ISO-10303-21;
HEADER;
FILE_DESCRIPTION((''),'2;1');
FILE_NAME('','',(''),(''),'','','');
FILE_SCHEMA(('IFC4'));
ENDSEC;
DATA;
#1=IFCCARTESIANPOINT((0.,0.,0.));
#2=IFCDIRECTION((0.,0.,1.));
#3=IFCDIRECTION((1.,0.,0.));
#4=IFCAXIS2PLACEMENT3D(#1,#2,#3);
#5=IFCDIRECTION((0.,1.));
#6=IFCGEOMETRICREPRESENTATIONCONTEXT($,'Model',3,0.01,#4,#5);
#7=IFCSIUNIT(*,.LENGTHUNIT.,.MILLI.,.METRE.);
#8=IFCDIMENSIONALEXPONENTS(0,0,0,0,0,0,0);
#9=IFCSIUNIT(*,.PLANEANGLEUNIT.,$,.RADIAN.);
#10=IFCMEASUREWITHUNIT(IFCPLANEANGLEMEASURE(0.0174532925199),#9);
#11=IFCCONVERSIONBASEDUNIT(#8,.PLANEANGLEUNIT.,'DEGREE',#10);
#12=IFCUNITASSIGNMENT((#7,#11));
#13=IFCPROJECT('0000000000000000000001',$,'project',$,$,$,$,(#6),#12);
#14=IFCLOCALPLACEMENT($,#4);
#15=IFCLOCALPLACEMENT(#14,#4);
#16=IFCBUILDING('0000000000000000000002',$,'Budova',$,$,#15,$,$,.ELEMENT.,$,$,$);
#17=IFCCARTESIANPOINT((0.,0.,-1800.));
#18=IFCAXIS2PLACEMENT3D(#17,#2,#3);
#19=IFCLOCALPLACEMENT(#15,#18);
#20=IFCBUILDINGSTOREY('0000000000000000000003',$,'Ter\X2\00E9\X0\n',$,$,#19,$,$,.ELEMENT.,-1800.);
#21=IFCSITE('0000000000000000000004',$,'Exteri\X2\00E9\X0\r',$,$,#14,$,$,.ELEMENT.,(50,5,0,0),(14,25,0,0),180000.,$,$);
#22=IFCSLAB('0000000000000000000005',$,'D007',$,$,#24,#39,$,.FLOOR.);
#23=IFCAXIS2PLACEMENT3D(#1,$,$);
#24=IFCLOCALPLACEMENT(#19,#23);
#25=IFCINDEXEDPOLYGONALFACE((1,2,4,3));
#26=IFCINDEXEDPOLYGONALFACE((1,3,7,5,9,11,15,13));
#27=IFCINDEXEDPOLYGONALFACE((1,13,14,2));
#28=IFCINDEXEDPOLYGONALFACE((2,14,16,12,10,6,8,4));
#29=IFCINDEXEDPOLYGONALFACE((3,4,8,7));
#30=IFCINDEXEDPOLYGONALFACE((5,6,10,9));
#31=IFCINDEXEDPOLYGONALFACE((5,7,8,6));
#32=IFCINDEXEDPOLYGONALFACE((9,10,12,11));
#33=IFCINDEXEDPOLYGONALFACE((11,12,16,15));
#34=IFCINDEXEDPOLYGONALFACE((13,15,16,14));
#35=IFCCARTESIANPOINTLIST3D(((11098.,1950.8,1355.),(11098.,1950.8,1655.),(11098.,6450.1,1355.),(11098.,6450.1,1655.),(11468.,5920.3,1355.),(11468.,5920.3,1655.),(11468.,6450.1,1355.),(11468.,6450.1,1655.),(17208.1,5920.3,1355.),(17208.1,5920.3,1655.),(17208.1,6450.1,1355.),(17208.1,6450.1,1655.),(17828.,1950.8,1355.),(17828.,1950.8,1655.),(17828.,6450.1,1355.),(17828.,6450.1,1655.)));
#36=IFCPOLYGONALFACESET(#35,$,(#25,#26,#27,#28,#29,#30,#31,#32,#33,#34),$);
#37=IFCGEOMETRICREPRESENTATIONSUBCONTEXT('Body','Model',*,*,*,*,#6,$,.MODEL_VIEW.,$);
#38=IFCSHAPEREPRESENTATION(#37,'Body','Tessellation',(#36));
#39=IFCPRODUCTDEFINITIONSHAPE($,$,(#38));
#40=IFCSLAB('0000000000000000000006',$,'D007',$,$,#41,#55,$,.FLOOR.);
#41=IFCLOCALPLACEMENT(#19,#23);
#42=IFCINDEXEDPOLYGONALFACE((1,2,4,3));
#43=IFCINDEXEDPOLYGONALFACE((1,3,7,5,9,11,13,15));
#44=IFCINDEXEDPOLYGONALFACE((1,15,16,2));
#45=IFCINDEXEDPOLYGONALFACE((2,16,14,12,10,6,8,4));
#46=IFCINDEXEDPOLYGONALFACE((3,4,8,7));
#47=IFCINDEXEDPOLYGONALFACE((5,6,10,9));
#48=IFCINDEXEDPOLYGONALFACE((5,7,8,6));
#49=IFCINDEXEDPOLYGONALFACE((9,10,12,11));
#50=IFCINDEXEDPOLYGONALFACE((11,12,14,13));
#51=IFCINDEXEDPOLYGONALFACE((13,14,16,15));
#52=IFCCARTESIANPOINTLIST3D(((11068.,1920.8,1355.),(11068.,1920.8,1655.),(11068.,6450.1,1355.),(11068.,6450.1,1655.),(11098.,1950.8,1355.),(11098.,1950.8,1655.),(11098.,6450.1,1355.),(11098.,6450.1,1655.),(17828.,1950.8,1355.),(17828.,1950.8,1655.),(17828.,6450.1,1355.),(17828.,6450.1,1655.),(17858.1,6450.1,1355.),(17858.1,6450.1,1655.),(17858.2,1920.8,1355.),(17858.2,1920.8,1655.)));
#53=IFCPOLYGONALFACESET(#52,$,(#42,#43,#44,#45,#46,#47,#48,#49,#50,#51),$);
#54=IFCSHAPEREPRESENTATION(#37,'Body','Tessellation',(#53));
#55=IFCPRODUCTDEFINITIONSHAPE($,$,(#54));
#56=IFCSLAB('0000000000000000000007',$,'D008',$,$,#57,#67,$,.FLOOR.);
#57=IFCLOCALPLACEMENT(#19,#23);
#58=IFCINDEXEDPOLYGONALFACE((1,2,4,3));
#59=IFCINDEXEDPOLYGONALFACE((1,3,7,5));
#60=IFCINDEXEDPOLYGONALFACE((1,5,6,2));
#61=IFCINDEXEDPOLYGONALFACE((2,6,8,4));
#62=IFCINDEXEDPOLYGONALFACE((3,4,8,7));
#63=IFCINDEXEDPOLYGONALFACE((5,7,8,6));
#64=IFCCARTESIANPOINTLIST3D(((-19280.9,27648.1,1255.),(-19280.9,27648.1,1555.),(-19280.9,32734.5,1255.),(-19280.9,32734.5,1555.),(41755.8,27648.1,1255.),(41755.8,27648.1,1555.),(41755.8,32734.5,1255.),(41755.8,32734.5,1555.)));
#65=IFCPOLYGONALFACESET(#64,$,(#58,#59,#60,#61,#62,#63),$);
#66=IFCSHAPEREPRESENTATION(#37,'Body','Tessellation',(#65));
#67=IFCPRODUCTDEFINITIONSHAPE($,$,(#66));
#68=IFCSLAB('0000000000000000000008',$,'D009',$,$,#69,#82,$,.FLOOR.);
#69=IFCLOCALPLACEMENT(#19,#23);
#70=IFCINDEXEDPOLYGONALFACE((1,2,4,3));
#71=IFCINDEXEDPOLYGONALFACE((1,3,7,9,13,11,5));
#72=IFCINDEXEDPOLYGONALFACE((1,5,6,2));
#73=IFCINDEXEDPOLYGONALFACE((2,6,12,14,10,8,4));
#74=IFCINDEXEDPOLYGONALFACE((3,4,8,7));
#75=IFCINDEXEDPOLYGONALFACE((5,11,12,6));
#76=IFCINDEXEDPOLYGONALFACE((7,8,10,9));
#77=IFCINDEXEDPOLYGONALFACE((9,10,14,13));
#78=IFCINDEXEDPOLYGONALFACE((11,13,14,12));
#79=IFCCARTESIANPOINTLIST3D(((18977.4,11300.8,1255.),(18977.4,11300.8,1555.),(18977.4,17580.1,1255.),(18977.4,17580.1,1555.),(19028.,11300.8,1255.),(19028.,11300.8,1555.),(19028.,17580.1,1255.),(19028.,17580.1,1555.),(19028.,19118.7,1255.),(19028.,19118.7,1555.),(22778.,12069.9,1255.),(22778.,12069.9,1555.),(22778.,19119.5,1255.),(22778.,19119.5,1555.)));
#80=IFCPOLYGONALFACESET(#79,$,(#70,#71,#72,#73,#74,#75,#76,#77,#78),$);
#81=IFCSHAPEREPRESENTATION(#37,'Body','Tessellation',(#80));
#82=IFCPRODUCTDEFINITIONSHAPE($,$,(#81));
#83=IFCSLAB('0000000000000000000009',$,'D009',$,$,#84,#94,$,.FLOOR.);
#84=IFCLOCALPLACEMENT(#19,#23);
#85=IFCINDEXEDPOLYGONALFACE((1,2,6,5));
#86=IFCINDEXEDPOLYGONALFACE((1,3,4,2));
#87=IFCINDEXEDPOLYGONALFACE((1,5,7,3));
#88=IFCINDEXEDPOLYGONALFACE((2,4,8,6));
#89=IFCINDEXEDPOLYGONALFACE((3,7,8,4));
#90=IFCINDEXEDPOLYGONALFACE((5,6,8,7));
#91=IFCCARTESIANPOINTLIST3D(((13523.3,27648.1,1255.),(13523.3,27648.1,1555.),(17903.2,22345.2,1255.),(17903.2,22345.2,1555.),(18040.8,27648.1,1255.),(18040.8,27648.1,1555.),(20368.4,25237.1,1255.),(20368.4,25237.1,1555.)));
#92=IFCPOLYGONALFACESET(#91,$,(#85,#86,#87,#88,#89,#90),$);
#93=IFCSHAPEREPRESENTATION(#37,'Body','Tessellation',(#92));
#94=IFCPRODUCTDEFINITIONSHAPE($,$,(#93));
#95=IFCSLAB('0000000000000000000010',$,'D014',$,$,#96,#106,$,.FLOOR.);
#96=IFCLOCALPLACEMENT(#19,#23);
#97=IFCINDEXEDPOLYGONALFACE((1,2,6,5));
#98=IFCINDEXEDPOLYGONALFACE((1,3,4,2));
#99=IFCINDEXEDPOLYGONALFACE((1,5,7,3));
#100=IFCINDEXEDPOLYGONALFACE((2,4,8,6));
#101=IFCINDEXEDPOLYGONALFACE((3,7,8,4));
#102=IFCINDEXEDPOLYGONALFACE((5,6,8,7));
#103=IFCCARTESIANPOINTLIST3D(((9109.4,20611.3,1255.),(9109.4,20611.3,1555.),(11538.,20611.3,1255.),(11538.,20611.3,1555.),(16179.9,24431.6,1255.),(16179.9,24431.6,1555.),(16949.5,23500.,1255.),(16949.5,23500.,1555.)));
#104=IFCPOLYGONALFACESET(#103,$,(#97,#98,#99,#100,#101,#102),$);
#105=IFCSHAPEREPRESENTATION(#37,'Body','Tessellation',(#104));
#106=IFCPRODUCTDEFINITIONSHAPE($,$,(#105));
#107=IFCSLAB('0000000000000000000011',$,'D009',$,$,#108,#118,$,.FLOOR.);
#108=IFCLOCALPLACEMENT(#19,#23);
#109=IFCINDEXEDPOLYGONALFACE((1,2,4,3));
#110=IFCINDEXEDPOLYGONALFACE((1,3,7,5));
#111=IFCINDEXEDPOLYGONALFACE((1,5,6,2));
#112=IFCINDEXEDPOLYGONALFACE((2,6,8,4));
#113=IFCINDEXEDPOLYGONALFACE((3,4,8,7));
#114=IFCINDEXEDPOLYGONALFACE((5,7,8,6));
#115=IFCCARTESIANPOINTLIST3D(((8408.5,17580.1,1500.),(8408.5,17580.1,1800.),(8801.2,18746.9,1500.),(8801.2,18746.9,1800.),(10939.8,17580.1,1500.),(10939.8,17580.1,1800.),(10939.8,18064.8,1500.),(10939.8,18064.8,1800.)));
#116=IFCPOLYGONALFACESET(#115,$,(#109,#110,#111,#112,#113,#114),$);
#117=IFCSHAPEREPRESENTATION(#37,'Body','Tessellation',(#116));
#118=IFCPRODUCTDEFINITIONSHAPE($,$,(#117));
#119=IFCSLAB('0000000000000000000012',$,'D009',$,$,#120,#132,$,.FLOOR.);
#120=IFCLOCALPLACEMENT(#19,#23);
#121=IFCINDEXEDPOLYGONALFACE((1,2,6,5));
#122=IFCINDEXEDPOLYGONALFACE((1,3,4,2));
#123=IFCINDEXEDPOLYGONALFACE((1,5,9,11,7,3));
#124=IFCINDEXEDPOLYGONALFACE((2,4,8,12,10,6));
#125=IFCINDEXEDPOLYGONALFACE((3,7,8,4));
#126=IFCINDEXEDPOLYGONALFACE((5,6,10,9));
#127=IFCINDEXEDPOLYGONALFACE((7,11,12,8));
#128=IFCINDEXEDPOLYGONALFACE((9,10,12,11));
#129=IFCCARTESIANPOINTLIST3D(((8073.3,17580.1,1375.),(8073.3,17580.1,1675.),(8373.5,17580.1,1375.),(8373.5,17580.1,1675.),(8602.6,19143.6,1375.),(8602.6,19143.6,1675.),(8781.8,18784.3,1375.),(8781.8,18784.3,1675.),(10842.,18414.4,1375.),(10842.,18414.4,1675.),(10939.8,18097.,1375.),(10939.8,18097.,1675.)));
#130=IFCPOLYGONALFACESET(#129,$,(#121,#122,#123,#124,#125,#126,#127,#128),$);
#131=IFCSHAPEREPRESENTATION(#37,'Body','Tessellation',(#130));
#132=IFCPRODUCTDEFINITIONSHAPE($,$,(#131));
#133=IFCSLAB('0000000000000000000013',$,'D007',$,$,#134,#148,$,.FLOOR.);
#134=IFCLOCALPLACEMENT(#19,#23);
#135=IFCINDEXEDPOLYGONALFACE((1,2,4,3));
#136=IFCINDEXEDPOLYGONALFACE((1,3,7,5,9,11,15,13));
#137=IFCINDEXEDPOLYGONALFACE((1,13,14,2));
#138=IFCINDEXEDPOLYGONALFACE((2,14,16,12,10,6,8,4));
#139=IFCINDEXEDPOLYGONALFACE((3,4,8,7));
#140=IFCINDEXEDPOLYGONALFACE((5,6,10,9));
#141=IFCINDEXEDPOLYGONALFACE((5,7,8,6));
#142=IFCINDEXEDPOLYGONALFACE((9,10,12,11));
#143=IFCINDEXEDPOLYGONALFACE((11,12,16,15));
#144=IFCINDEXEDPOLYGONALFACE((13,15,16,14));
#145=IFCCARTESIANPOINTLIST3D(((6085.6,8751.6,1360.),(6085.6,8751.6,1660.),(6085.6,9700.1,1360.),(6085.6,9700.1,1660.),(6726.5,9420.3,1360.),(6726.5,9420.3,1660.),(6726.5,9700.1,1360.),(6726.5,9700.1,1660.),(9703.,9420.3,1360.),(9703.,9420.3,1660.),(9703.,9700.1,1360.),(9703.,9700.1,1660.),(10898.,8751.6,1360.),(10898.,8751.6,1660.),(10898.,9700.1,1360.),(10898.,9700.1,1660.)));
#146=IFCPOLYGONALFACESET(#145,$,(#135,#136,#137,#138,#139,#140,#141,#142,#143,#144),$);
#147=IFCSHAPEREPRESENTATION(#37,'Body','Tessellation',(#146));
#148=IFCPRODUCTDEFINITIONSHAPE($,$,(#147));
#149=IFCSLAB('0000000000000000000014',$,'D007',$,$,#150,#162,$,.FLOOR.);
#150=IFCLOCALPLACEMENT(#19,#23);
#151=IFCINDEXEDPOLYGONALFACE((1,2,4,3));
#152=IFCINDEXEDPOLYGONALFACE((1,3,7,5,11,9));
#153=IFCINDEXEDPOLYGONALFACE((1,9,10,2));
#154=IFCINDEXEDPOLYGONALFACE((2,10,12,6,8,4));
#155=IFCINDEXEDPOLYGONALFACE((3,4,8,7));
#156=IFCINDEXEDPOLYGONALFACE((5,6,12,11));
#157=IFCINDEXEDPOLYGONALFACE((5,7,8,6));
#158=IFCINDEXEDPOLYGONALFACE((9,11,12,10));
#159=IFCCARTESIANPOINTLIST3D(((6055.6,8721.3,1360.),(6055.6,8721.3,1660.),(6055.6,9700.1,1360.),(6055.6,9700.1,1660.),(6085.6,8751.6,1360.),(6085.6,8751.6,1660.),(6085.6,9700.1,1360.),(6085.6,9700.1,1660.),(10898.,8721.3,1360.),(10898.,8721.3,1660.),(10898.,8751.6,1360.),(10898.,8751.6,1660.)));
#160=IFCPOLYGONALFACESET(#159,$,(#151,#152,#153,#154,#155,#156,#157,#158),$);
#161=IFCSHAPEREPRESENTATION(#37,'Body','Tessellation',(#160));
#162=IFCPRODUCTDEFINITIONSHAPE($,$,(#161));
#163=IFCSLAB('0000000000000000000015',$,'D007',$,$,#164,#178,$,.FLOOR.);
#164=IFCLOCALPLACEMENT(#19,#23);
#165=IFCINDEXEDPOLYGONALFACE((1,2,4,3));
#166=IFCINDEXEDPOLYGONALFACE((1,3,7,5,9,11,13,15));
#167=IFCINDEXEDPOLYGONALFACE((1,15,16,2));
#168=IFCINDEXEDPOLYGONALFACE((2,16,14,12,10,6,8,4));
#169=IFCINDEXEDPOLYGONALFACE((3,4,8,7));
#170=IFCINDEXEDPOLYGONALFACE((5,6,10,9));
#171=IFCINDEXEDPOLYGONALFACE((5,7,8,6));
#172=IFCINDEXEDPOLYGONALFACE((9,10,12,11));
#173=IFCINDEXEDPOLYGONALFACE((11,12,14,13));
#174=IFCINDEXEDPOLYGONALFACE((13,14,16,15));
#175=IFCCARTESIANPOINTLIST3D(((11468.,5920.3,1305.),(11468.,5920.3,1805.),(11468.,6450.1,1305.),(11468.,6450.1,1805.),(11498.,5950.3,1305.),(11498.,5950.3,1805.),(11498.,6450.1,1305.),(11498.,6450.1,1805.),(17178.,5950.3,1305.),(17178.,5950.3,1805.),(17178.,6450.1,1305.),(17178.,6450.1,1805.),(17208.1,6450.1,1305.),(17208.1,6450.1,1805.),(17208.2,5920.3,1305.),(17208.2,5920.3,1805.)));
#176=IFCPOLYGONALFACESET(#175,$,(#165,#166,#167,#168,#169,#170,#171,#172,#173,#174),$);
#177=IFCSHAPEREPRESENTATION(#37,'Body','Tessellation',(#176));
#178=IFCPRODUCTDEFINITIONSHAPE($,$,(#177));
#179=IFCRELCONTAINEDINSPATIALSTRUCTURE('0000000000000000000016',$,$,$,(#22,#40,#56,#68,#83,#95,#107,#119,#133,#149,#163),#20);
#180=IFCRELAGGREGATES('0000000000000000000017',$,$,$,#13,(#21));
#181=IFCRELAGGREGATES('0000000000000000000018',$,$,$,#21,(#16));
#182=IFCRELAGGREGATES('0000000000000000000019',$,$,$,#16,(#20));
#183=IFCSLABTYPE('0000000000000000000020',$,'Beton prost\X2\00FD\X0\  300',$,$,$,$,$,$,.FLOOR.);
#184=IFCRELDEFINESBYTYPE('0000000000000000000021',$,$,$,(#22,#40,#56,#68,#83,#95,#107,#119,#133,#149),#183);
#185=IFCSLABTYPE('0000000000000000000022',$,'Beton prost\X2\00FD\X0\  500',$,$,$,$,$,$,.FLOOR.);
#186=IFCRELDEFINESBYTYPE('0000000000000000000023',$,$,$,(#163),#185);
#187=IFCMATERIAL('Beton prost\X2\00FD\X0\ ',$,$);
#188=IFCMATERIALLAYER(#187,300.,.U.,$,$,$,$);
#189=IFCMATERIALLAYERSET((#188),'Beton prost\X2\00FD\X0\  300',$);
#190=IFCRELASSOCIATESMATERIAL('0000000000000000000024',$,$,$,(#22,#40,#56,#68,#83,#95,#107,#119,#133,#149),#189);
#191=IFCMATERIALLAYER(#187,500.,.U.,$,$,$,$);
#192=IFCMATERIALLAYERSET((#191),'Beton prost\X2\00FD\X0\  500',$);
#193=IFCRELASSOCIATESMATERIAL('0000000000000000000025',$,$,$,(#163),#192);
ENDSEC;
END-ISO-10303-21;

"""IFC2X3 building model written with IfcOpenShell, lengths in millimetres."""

from ifc_helpers import new_model, entity, si_unit, converted_unit, direction, frame, origin_with_axes, place, context, subcontext, project, spatial, polyline, outline, extrude, material, layer, layer_set, layer_usage, type_object, element, save


model = new_model("IFC2X3")

# Units and contexts
model_context = context("Model", 3, precision=0.01, world=origin_with_axes(), true_north=direction((0.0, 1.0)))
body_context = subcontext(model_context, "Body", "Model", "MODEL_VIEW")
ifc_project = project(units=[si_unit("LENGTHUNIT", "METRE", prefix="MILLI"), converted_unit("PLANEANGLEUNIT", "DEGREE", entity("IfcPlaneAngleMeasure", 0.0174532925199), si_unit("PLANEANGLEUNIT", "RADIAN"), dimensions=[0, 0, 0, 0, 0, 0, 0])], contexts=[model_context])

# Site, building, storey
site_placement = place(None, origin_with_axes())
site = spatial("IfcSite", under=ifc_project, at=site_placement, Name="Exteriér", CompositionType="ELEMENT", RefLatitude=(50, 5, 0, 0), RefLongitude=(14, 25, 0, 0), RefElevation=180000.0)
building_placement = place(site_placement, origin_with_axes())
building = spatial("IfcBuilding", under=site, at=building_placement, Name="Budova", CompositionType="ELEMENT")
storey_placement = place(building_placement, frame((0.0, 0.0, -1800.0), z_axis=(0.0, 0.0, 1.0), x_axis=(1.0, 0.0, 0.0)))
storey = spatial("IfcBuildingStorey", under=building, at=storey_placement, Name="Terén", CompositionType="ELEMENT", Elevation=-1800.0)

# Slabs
ifc_material_1 = material(Name="Beton prostý ")
ifc_layer_1 = layer(ifc_material_1, 300.0, ventilated="UNKNOWN")
ifc_layer_set_1 = layer_set([ifc_layer_1], Name="Beton prostý  300")
ifc_layer_usage_1 = layer_usage(ifc_layer_set_1, "AXIS3", "NEGATIVE", 300.0)
slab_type_1 = type_object("IfcSlabType", Name="Beton prostý  300", PredefinedType="FLOOR")
slab_1_placement = place(storey_placement, frame((11098.0, 1950.8, 1655.0), z_axis=(0.0, 0.0, 1.0), x_axis=(1.0, 0.0, 0.0)))
element("IfcSlab", 1, at=slab_1_placement, inside=storey, type_object=slab_type_1, material=ifc_layer_usage_1, Name="D007", PredefinedType="FLOOR", context=body_context, shape_type="SweptSolid", body=[
    extrude(outline(polyline([(0.0, 0.0), (6730.0, 0.0), (6730.0, 4499.3), (6110.1, 4499.3), (6110.1, 3969.5), (370.0, 3969.5), (370.0, 4499.3), (0.0, 4499.3), (0.0, 0.0)])), frame((0.0, 0.0, -300.0), z_axis=(0.0, 0.0, 1.0), x_axis=(1.0, 0.0, 0.0)), (0.0, 0.0, 1.0), 300.0),
])
ifc_layer_usage_2 = layer_usage(ifc_layer_set_1, "AXIS3", "NEGATIVE", 300.0)
slab_2_placement = place(storey_placement, frame((11068.0, 6450.1, 1655.0), z_axis=(0.0, 0.0, 1.0), x_axis=(1.0, 0.0, 0.0)))
element("IfcSlab", 2, at=slab_2_placement, inside=storey, type_object=slab_type_1, material=ifc_layer_usage_2, Name="D007", PredefinedType="FLOOR", context=body_context, shape_type="SweptSolid", body=[
    extrude(outline(polyline([(0.0, 0.0), (0.0, -4529.3), (6790.2, -4529.3), (6790.1, 0.0), (6760.0, 0.0), (6760.0, -4499.3), (30.0, -4499.3), (30.0, 0.0), (0.0, 0.0)])), frame((0.0, 0.0, -300.0), z_axis=(0.0, 0.0, 1.0), x_axis=(1.0, 0.0, 0.0)), (0.0, 0.0, 1.0), 300.0),
])
ifc_layer_usage_3 = layer_usage(ifc_layer_set_1, "AXIS3", "NEGATIVE", 300.0)
slab_3_placement = place(storey_placement, frame((-19280.9, 27648.1, 1555.0), z_axis=(0.0, 0.0, 1.0), x_axis=(1.0, 0.0, 0.0)))
element("IfcSlab", 3, at=slab_3_placement, inside=storey, type_object=slab_type_1, material=ifc_layer_usage_3, Name="D008", PredefinedType="FLOOR", context=body_context, shape_type="SweptSolid", body=[
    extrude(outline(polyline([(0.0, 0.0), (61036.7, 0.0), (61036.7, 5086.4), (0.0, 5086.4), (0.0, 0.0)])), frame((0.0, 0.0, -300.0), z_axis=(0.0, 0.0, 1.0), x_axis=(1.0, 0.0, 0.0)), (0.0, 0.0, 1.0), 300.0),
])
ifc_layer_usage_4 = layer_usage(ifc_layer_set_1, "AXIS3", "NEGATIVE", 300.0)
slab_4_placement = place(storey_placement, frame((18977.4, 11300.8, 1555.0), z_axis=(0.0, 0.0, 1.0), x_axis=(1.0, 0.0, 0.0)))
element("IfcSlab", 4, at=slab_4_placement, inside=storey, type_object=slab_type_1, material=ifc_layer_usage_4, Name="D009", PredefinedType="FLOOR", context=body_context, shape_type="SweptSolid", body=[
    extrude(outline(polyline([(0.0, 0.0), (50.6, 0.0), (3800.6, 769.0), (3800.6, 7818.7), (50.6, 7817.9), (50.6, 6279.3), (0.0, 6279.3), (0.0, 0.0)])), frame((0.0, 0.0, -300.0), z_axis=(0.0, 0.0, 1.0), x_axis=(1.0, 0.0, 0.0)), (0.0, 0.0, 1.0), 300.0),
])
ifc_layer_usage_5 = layer_usage(ifc_layer_set_1, "AXIS3", "NEGATIVE", 300.0)
slab_5_placement = place(storey_placement, frame((18040.8, 27648.1, 1555.0), z_axis=(0.0, 0.0, 1.0), x_axis=(1.0, 0.0, 0.0)))
element("IfcSlab", 5, at=slab_5_placement, inside=storey, type_object=slab_type_1, material=ifc_layer_usage_5, Name="D009", PredefinedType="FLOOR", context=body_context, shape_type="SweptSolid", body=[
    extrude(outline(polyline([(0.0, 0.0), (-4517.5, 0.0), (-137.5, -5302.9), (2327.6, -2410.9), (0.0, 0.0)])), frame((0.0, 0.0, -300.0), z_axis=(0.0, 0.0, 1.0), x_axis=(1.0, 0.0, 0.0)), (0.0, 0.0, 1.0), 300.0),
])
ifc_layer_usage_6 = layer_usage(ifc_layer_set_1, "AXIS3", "NEGATIVE", 300.0)
slab_6_placement = place(storey_placement, frame((11538.0, 20611.3, 1555.0), z_axis=(0.0, 0.0, 1.0), x_axis=(1.0, 0.0, 0.0)))
element("IfcSlab", 6, at=slab_6_placement, inside=storey, type_object=slab_type_1, material=ifc_layer_usage_6, Name="D014", PredefinedType="FLOOR", context=body_context, shape_type="SweptSolid", body=[
    extrude(outline(polyline([(0.0, 0.0), (5411.4, 2888.6), (4641.9, 3820.3), (-2428.6, 0.0), (0.0, 0.0)])), frame((0.0, 0.0, -300.0), z_axis=(0.0, 0.0, 1.0), x_axis=(1.0, 0.0, 0.0)), (0.0, 0.0, 1.0), 300.0),
])
ifc_layer_usage_7 = layer_usage(ifc_layer_set_1, "AXIS3", "NEGATIVE", 300.0)
slab_7_placement = place(storey_placement, frame((10939.8, 18064.8, 1800.0), z_axis=(0.0, 0.0, 1.0), x_axis=(1.0, 0.0, 0.0)))
element("IfcSlab", 7, at=slab_7_placement, inside=storey, type_object=slab_type_1, material=ifc_layer_usage_7, Name="D009", PredefinedType="FLOOR", context=body_context, shape_type="SweptSolid", body=[
    extrude(outline(polyline([(0.0, 0.0), (-2138.6, 682.1), (-2531.3, -484.6), (0.0, -484.6), (0.0, 0.0)])), frame((0.0, 0.0, -300.0), z_axis=(0.0, 0.0, 1.0), x_axis=(1.0, 0.0, 0.0)), (0.0, 0.0, 1.0), 300.0),
])
ifc_layer_usage_8 = layer_usage(ifc_layer_set_1, "AXIS3", "NEGATIVE", 300.0)
slab_8_placement = place(storey_placement, frame((8073.3, 17580.1, 1675.0), z_axis=(0.0, 0.0, 1.0), x_axis=(1.0, 0.0, 0.0)))
element("IfcSlab", 8, at=slab_8_placement, inside=storey, type_object=slab_type_1, material=ifc_layer_usage_8, Name="D009", PredefinedType="FLOOR", context=body_context, shape_type="SweptSolid", body=[
    extrude(outline(polyline([(0.0, 0.0), (300.2, 0.0), (708.5, 1204.1), (2866.5, 516.8), (2768.7, 834.2), (529.3, 1563.5), (0.0, 0.0)])), frame((0.0, 0.0, -300.0), z_axis=(0.0, 0.0, 1.0), x_axis=(1.0, 0.0, 0.0)), (0.0, 0.0, 1.0), 300.0),
])
ifc_layer_usage_9 = layer_usage(ifc_layer_set_1, "AXIS3", "NEGATIVE", 300.0)
slab_9_placement = place(storey_placement, frame((6085.6, 8751.6, 1660.0), z_axis=(0.0, 0.0, 1.0), x_axis=(1.0, 0.0, 0.0)))
element("IfcSlab", 9, at=slab_9_placement, inside=storey, type_object=slab_type_1, material=ifc_layer_usage_9, Name="D007", PredefinedType="FLOOR", context=body_context, shape_type="SweptSolid", body=[
    extrude(outline(polyline([(0.0, 0.0), (4812.4, 0.0), (4812.4, 948.5), (3617.3, 948.5), (3617.3, 668.7), (640.9, 668.7), (640.9, 948.5), (0.0, 948.5), (0.0, 0.0)])), frame((0.0, 0.0, -300.0), z_axis=(0.0, 0.0, 1.0), x_axis=(1.0, 0.0, 0.0)), (0.0, 0.0, 1.0), 300.0),
])
ifc_layer_usage_10 = layer_usage(ifc_layer_set_1, "AXIS3", "NEGATIVE", 300.0)
slab_10_placement = place(storey_placement, frame((6085.6, 9700.1, 1660.0), z_axis=(0.0, 0.0, 1.0), x_axis=(1.0, 0.0, 0.0)))
element("IfcSlab", 10, at=slab_10_placement, inside=storey, type_object=slab_type_1, material=ifc_layer_usage_10, Name="D007", PredefinedType="FLOOR", context=body_context, shape_type="SweptSolid", body=[
    extrude(outline(polyline([(0.0, 0.0), (-30.0, 0.0), (-30.0, -978.9), (4812.4, -978.9), (4812.4, -948.5), (0.0, -948.5), (0.0, 0.0)])), frame((0.0, 0.0, -300.0), z_axis=(0.0, 0.0, 1.0), x_axis=(1.0, 0.0, 0.0)), (0.0, 0.0, 1.0), 300.0),
])
ifc_layer_2 = layer(ifc_material_1, 500.0, ventilated="UNKNOWN")
ifc_layer_set_2 = layer_set([ifc_layer_2], Name="Beton prostý  500")
ifc_layer_usage_11 = layer_usage(ifc_layer_set_2, "AXIS3", "NEGATIVE", 500.0)
slab_type_2 = type_object("IfcSlabType", Name="Beton prostý  500", PredefinedType="FLOOR")
slab_11_placement = place(storey_placement, frame((11468.0, 6450.1, 1805.0), z_axis=(0.0, 0.0, 1.0), x_axis=(1.0, 0.0, 0.0)))
element("IfcSlab", 11, at=slab_11_placement, inside=storey, type_object=slab_type_2, material=ifc_layer_usage_11, Name="D007", PredefinedType="FLOOR", context=body_context, shape_type="SweptSolid", body=[
    extrude(outline(polyline([(0.0, 0.0), (0.0, -529.8), (5740.2, -529.8), (5740.1, 0.0), (5710.0, 0.0), (5710.0, -499.8), (30.0, -499.8), (30.0, 0.0), (0.0, 0.0)])), frame((0.0, 0.0, -500.0), z_axis=(0.0, 0.0, 1.0), x_axis=(1.0, 0.0, 0.0)), (0.0, 0.0, 1.0), 500.0),
])

save(model, "model.ifc")
